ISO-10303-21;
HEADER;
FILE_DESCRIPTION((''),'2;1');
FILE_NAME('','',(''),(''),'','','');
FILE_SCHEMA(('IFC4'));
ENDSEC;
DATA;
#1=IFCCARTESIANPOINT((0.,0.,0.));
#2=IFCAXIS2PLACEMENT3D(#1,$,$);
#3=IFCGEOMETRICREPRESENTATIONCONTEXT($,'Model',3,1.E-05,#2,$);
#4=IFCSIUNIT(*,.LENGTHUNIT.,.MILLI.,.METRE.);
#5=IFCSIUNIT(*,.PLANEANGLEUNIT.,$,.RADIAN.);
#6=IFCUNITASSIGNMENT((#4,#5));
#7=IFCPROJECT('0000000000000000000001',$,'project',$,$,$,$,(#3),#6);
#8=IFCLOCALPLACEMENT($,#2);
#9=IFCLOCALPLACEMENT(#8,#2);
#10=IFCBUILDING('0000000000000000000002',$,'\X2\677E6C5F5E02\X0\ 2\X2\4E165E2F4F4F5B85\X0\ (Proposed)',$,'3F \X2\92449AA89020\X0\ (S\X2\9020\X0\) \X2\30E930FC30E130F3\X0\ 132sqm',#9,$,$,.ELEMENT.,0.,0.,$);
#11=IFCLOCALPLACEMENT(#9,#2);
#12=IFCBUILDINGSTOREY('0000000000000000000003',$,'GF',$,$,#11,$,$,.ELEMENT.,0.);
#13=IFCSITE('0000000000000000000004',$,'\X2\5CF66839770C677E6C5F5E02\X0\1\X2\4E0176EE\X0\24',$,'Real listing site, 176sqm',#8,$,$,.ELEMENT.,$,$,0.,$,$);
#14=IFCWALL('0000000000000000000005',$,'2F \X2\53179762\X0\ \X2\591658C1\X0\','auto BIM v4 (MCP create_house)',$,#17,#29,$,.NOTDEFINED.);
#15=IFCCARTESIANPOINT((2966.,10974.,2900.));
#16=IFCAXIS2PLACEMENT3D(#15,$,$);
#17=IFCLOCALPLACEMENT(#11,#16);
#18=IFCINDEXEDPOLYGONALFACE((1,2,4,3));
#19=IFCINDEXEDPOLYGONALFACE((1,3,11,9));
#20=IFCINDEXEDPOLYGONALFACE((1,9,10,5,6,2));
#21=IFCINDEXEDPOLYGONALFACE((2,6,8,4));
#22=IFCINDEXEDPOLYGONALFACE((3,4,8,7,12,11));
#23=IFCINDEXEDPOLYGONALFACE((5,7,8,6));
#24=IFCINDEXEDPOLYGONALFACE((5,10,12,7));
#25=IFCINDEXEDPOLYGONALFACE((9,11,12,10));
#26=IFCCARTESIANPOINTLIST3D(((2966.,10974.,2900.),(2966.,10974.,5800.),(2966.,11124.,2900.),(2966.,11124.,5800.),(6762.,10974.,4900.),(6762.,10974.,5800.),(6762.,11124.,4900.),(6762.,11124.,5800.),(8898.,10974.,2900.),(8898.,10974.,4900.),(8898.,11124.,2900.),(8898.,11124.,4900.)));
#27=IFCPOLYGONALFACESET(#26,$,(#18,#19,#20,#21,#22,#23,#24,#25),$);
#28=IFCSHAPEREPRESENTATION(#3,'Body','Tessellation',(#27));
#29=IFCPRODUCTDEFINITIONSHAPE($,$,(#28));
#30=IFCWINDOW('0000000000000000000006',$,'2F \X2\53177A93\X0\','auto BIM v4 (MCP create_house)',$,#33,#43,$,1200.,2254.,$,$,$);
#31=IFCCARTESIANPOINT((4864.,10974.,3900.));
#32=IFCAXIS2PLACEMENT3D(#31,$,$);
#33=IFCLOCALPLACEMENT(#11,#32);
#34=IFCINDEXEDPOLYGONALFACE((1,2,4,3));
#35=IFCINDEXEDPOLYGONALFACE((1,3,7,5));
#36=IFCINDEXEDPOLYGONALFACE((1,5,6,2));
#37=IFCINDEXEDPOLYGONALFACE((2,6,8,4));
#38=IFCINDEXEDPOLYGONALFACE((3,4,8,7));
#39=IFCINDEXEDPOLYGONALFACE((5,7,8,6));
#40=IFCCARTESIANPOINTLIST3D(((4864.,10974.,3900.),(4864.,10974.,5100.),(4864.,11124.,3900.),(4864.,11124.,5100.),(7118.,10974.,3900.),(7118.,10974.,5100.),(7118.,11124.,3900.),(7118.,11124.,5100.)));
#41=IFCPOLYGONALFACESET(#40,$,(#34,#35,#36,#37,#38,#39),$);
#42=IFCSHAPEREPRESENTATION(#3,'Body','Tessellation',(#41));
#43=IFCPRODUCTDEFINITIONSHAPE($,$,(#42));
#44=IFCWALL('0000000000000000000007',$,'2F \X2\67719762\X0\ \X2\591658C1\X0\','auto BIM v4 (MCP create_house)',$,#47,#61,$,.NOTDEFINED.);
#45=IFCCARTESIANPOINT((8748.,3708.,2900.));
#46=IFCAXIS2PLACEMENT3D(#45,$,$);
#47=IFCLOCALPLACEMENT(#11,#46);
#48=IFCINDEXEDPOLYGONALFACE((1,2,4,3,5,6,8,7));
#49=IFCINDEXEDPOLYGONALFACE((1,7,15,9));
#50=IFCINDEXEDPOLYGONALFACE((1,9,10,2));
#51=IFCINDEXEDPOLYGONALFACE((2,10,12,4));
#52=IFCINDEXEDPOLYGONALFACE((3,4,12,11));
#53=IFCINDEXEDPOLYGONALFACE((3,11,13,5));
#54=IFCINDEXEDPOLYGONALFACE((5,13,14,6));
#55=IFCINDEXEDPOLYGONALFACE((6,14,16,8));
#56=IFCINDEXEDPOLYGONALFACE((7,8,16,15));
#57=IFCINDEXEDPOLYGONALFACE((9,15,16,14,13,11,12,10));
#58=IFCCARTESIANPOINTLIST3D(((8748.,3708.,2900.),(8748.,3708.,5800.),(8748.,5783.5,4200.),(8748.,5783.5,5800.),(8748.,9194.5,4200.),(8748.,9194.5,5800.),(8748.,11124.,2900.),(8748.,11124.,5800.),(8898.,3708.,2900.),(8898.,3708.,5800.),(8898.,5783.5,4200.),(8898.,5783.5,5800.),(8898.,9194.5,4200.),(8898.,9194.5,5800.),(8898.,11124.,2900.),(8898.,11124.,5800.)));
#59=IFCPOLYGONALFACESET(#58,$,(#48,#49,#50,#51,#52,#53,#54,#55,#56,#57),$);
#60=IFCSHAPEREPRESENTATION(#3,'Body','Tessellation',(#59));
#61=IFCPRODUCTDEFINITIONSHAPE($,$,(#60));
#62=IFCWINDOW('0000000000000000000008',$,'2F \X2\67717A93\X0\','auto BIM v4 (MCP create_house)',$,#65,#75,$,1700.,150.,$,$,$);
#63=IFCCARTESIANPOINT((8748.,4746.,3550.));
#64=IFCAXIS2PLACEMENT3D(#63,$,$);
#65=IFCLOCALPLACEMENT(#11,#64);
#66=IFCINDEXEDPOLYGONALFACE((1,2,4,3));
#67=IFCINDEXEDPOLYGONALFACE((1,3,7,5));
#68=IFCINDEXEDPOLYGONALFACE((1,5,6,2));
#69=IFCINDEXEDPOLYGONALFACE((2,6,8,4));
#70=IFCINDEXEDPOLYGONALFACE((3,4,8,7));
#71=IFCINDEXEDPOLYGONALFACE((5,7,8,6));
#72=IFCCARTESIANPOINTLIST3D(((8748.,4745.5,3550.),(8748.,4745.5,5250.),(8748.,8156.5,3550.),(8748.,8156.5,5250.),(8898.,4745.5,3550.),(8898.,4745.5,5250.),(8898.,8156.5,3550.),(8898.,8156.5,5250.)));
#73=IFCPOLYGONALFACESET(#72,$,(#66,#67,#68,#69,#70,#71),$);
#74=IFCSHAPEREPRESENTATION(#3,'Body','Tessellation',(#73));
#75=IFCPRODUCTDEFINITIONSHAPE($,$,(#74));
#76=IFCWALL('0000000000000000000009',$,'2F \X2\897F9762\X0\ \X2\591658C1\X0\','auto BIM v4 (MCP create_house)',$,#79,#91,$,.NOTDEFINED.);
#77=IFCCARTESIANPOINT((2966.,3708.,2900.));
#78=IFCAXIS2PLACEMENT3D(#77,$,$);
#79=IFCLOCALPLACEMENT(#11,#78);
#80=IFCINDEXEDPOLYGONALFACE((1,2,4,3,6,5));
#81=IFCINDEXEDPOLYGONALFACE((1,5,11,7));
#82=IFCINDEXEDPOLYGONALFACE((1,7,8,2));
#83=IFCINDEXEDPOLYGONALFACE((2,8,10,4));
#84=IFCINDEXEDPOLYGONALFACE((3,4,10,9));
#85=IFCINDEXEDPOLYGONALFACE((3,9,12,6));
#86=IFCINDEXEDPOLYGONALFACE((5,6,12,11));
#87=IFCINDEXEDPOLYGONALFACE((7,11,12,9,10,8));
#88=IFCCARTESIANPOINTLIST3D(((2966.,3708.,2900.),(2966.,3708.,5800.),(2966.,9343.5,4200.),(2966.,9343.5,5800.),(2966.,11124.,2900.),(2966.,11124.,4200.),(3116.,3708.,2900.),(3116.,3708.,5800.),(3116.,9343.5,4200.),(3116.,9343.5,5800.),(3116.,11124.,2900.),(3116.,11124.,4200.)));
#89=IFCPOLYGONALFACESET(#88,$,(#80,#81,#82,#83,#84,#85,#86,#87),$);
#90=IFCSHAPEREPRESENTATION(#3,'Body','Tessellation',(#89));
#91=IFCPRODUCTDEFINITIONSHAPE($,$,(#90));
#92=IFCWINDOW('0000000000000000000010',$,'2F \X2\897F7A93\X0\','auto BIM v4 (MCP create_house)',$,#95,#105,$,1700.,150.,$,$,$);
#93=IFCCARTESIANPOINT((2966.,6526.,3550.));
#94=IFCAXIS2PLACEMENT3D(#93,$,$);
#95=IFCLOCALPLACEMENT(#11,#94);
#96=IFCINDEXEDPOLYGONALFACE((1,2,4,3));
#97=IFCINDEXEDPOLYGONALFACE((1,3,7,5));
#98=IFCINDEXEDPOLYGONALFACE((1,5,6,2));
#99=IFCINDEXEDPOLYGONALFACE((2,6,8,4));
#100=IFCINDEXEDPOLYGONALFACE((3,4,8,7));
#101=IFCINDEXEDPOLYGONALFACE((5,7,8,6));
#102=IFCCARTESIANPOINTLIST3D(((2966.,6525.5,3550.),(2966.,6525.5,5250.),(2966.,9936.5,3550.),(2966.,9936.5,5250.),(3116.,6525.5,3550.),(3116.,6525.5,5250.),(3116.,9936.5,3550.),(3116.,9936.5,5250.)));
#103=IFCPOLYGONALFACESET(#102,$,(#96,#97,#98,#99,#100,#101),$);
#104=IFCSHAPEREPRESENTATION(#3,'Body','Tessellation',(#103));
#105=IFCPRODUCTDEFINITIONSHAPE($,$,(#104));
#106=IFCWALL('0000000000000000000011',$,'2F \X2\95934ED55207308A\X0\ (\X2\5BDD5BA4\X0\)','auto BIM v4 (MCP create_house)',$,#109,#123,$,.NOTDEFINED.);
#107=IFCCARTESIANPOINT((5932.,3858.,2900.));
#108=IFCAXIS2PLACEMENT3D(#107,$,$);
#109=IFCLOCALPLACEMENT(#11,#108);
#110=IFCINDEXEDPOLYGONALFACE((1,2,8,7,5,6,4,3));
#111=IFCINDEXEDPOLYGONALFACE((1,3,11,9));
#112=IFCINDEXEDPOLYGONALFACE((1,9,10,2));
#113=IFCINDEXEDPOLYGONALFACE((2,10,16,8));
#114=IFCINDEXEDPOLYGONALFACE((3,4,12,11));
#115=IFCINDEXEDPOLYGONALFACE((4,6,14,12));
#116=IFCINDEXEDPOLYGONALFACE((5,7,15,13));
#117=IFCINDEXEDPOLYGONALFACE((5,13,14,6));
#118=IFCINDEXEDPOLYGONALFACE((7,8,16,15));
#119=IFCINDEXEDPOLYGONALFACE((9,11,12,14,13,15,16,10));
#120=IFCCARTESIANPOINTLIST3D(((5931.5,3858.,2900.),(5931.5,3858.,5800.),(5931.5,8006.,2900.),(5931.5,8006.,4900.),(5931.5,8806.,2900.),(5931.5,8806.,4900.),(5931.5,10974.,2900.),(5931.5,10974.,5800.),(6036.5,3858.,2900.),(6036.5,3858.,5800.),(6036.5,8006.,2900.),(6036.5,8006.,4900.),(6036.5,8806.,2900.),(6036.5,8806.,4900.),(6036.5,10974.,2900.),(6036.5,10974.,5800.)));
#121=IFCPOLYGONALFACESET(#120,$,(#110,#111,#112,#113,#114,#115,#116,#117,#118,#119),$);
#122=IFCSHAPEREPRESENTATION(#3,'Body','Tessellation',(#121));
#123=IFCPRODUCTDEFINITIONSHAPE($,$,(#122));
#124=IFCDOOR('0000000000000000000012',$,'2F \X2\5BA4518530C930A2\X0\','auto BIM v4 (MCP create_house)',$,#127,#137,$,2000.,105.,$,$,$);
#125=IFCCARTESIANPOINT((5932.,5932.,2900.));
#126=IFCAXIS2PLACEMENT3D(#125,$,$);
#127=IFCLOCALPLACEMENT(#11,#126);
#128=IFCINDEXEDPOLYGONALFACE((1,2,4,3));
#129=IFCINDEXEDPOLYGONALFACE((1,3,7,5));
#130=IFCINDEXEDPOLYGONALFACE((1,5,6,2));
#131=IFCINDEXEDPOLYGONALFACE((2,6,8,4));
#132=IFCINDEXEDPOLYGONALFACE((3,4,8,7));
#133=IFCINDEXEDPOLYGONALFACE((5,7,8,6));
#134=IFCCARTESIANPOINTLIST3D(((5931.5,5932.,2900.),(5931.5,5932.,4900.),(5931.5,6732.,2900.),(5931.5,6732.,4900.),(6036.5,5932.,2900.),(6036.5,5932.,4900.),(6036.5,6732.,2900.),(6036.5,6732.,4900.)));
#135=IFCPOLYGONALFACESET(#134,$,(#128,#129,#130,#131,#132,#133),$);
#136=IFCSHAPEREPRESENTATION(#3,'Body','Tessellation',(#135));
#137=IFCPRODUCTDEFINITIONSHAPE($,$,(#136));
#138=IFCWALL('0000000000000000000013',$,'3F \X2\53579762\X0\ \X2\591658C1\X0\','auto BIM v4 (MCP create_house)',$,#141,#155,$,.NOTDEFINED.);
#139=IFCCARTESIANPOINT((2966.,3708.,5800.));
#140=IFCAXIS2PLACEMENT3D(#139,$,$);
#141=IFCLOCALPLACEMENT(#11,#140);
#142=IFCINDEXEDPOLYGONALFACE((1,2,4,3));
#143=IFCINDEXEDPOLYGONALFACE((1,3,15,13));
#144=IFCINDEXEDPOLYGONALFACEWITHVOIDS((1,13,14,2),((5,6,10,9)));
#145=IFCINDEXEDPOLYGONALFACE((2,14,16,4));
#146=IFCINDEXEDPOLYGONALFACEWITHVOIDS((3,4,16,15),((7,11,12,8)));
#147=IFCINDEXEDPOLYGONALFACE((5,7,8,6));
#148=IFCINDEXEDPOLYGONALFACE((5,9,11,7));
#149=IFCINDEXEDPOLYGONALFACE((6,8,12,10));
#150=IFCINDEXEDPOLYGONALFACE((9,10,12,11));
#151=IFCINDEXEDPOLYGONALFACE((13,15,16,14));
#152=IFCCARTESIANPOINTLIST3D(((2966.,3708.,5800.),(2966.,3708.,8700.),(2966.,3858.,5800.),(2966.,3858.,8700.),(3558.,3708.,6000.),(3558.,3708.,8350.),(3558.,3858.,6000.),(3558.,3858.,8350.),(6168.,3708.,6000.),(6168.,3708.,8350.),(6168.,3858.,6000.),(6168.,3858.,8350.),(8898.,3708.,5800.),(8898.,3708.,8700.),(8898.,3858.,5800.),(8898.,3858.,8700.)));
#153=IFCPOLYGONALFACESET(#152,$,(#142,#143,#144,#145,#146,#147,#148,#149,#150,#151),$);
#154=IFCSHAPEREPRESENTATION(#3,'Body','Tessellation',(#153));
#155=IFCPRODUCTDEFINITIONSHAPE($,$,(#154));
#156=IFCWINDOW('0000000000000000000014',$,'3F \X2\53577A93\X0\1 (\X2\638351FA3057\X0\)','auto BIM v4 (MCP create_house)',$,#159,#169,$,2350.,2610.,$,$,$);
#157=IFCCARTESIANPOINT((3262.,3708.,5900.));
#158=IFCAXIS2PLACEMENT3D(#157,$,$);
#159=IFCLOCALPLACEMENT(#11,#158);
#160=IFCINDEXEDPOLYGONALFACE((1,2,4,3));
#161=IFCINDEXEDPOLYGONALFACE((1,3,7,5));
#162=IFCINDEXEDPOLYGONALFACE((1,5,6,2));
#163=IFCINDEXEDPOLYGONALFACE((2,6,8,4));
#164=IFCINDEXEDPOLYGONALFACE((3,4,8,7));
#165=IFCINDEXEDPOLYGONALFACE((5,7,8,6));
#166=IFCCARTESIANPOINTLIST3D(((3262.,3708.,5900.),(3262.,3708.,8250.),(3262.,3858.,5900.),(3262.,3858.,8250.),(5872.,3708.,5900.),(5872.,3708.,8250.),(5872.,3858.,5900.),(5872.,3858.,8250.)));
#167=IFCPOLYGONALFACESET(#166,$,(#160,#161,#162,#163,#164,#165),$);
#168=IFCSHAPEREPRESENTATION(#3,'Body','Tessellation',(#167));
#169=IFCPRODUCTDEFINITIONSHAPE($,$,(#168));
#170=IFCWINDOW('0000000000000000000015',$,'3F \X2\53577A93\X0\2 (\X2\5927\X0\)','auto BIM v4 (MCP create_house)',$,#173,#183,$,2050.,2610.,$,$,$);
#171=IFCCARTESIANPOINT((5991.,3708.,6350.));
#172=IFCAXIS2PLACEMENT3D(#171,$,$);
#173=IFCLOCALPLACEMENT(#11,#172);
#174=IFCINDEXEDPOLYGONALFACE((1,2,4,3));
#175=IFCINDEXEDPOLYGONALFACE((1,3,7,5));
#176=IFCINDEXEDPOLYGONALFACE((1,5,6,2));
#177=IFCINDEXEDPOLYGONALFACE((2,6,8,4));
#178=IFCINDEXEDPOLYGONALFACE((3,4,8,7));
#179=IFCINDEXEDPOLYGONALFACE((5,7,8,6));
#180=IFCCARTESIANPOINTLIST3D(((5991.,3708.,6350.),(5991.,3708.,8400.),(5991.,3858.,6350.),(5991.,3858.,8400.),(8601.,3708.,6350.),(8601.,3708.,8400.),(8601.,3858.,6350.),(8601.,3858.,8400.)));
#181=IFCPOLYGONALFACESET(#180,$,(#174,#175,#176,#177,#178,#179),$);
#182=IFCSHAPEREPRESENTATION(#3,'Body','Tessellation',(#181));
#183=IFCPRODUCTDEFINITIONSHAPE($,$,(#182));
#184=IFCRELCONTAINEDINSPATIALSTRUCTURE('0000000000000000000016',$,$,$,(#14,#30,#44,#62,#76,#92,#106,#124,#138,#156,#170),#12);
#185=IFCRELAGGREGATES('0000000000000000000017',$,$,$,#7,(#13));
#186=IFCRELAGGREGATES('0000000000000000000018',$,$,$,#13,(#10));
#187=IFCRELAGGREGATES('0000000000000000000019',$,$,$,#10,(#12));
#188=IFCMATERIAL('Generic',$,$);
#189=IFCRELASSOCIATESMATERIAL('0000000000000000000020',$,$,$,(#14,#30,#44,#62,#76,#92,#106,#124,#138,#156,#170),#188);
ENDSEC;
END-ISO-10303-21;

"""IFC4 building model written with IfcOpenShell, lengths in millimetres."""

from ifc_helpers import new_model, si_unit, frame, frame_2d, origin, place, context, project, spatial, rectangle, extrude, material, element, fill, save


model = new_model("IFC4")

# Units and contexts
model_context = context("Model", 3, precision=1e-05, world=origin())
ifc_project = project(units=[si_unit("LENGTHUNIT", "METRE", prefix="MILLI"), si_unit("PLANEANGLEUNIT", "RADIAN")], contexts=[model_context])

# Site, building, storey
site_placement = place(None, origin())
site = spatial("IfcSite", under=ifc_project, at=site_placement, Name="島根県松江市1丁目24", ObjectType="Real listing site, 176sqm", CompositionType="ELEMENT", RefElevation=0.0)
building_placement = place(site_placement, origin())
building = spatial("IfcBuilding", under=site, at=building_placement, Name="松江市 2世帯住宅 (Proposed)", ObjectType="3F 鉄骨造 (S造) ラーメン 132sqm", CompositionType="ELEMENT", ElevationOfRefHeight=0.0, ElevationOfTerrain=0.0)
storey_placement = place(building_placement, origin())
storey = spatial("IfcBuildingStorey", under=building, at=storey_placement, Name="GF", CompositionType="ELEMENT", Elevation=0.0)

# Shared definitions
ifc_material = material(Name="Generic")

# Walls, openings, windows
wall_1_placement = place(storey_placement, frame((2966.0, 10974.0, 2900.0)))
wall_1 = element("IfcWall", 1, at=wall_1_placement, inside=storey, material=ifc_material, Name="2F 北面 外壁", Description="auto BIM v4 (MCP create_house)", PredefinedType="NOTDEFINED", context=model_context, shape_type="SweptSolid", body=[
    extrude(rectangle(XDim=5932.0, YDim=150.0, at=frame_2d((2966.0, 75.0))), frame((2966.0, 10974.0, 2900.0)), (0.0, 0.0, 1.0), 2900.0),
])
opening_1_placement = place(storey_placement, frame((4864.0, 10974.0, 3900.0)))
opening_1 = element("IfcOpeningElement", 2, at=opening_1_placement, cuts=wall_1, PredefinedType="NOTDEFINED", context=model_context, shape_type="SweptSolid", body=[
    extrude(rectangle(XDim=2254.0, YDim=150.0, at=frame_2d((1127.0, 75.0))), frame((4864.0, 10974.0, 3900.0)), (0.0, 0.0, 1.0), 1200.0),
])
window_1_placement = place(storey_placement, frame((4864.0, 10974.0, 3900.0)))
window_1 = element("IfcWindow", 3, at=window_1_placement, inside=storey, material=ifc_material, Name="2F 北窓", Description="auto BIM v4 (MCP create_house)", OverallHeight=1200.0, OverallWidth=2254.0, context=model_context, shape_type="SweptSolid", body=[
    extrude(rectangle(XDim=2254.0, YDim=150.0, at=frame_2d((1127.0, 75.0))), frame((4864.0, 10974.0, 3900.0)), (0.0, 0.0, 1.0), 1200.0),
])
fill(opening_1, window_1)
wall_2_placement = place(storey_placement, frame((8748.0, 3708.0, 2900.0)))
wall_2 = element("IfcWall", 4, at=wall_2_placement, inside=storey, material=ifc_material, Name="2F 東面 外壁", Description="auto BIM v4 (MCP create_house)", PredefinedType="NOTDEFINED", context=model_context, shape_type="SweptSolid", body=[
    extrude(rectangle(XDim=150.0, YDim=7416.0, at=frame_2d((75.0, 3708.0))), frame((8748.0, 3708.0, 2900.0)), (0.0, 0.0, 1.0), 2900.0),
])
opening_2_placement = place(storey_placement, frame((8748.0, 4746.0, 3550.0)))
opening_2 = element("IfcOpeningElement", 5, at=opening_2_placement, cuts=wall_2, PredefinedType="NOTDEFINED", context=model_context, shape_type="SweptSolid", body=[
    extrude(rectangle(XDim=150.0, YDim=3411.0, at=frame_2d((75.0, 1705.0))), frame((8748.0, 4746.0, 3550.0)), (0.0, 0.0, 1.0), 1700.0),
])
window_2_placement = place(storey_placement, frame((8748.0, 4746.0, 3550.0)))
window_2 = element("IfcWindow", 6, at=window_2_placement, inside=storey, material=ifc_material, Name="2F 東窓", Description="auto BIM v4 (MCP create_house)", OverallHeight=1700.0, OverallWidth=150.0, context=model_context, shape_type="SweptSolid", body=[
    extrude(rectangle(XDim=150.0, YDim=3411.0, at=frame_2d((75.0, 1705.0))), frame((8748.0, 4746.0, 3550.0)), (0.0, 0.0, 1.0), 1700.0),
])
fill(opening_2, window_2)
wall_3_placement = place(storey_placement, frame((2966.0, 3708.0, 2900.0)))
wall_3 = element("IfcWall", 7, at=wall_3_placement, inside=storey, material=ifc_material, Name="2F 西面 外壁", Description="auto BIM v4 (MCP create_house)", PredefinedType="NOTDEFINED", context=model_context, shape_type="SweptSolid", body=[
    extrude(rectangle(XDim=150.0, YDim=7416.0, at=frame_2d((75.0, 3708.0))), frame((2966.0, 3708.0, 2900.0)), (0.0, 0.0, 1.0), 2900.0),
])
opening_3_placement = place(storey_placement, frame((2966.0, 6526.0, 3550.0)))
opening_3 = element("IfcOpeningElement", 8, at=opening_3_placement, cuts=wall_3, PredefinedType="NOTDEFINED", context=model_context, shape_type="SweptSolid", body=[
    extrude(rectangle(XDim=150.0, YDim=3411.0, at=frame_2d((75.0, 1705.0))), frame((2966.0, 6526.0, 3550.0)), (0.0, 0.0, 1.0), 1700.0),
])
window_3_placement = place(storey_placement, frame((2966.0, 6526.0, 3550.0)))
window_3 = element("IfcWindow", 9, at=window_3_placement, inside=storey, material=ifc_material, Name="2F 西窓", Description="auto BIM v4 (MCP create_house)", OverallHeight=1700.0, OverallWidth=150.0, context=model_context, shape_type="SweptSolid", body=[
    extrude(rectangle(XDim=150.0, YDim=3411.0, at=frame_2d((75.0, 1705.0))), frame((2966.0, 6526.0, 3550.0)), (0.0, 0.0, 1.0), 1700.0),
])
fill(opening_3, window_3)

# Wall, opening, door
wall_4_placement = place(storey_placement, frame((5932.0, 3858.0, 2900.0)))
wall_4 = element("IfcWall", 10, at=wall_4_placement, inside=storey, material=ifc_material, Name="2F 間仕切り (寝室)", Description="auto BIM v4 (MCP create_house)", PredefinedType="NOTDEFINED", context=model_context, shape_type="SweptSolid", body=[
    extrude(rectangle(XDim=105.0, YDim=7116.0, at=frame_2d((52.0, 3558.0))), frame((5932.0, 3858.0, 2900.0)), (0.0, 0.0, 1.0), 2900.0),
])
opening_4_placement = place(storey_placement, frame((5932.0, 5932.0, 2900.0)))
opening_4 = element("IfcOpeningElement", 11, at=opening_4_placement, cuts=wall_4, PredefinedType="NOTDEFINED", context=model_context, shape_type="SweptSolid", body=[
    extrude(rectangle(XDim=105.0, YDim=800.0, at=frame_2d((52.0, 400.0))), frame((5932.0, 5932.0, 2900.0)), (0.0, 0.0, 1.0), 2000.0),
])
door_1_placement = place(storey_placement, frame((5932.0, 5932.0, 2900.0)))
door_1 = element("IfcDoor", 12, at=door_1_placement, inside=storey, material=ifc_material, Name="2F 室内ドア", Description="auto BIM v4 (MCP create_house)", OverallHeight=2000.0, OverallWidth=105.0, context=model_context, shape_type="SweptSolid", body=[
    extrude(rectangle(XDim=105.0, YDim=800.0, at=frame_2d((52.0, 400.0))), frame((5932.0, 5932.0, 2900.0)), (0.0, 0.0, 1.0), 2000.0),
])
fill(opening_4, door_1)

# Wall, openings, windows
wall_5_placement = place(storey_placement, frame((2966.0, 3708.0, 5800.0)))
wall_5 = element("IfcWall", 13, at=wall_5_placement, inside=storey, material=ifc_material, Name="3F 南面 外壁", Description="auto BIM v4 (MCP create_house)", PredefinedType="NOTDEFINED", context=model_context, shape_type="SweptSolid", body=[
    extrude(rectangle(XDim=5932.0, YDim=150.0, at=frame_2d((2966.0, 75.0))), frame((2966.0, 3708.0, 5800.0)), (0.0, 0.0, 1.0), 2900.0),
])
opening_5_placement = place(storey_placement, frame((3262.0, 3708.0, 5900.0)))
opening_5 = element("IfcOpeningElement", 14, at=opening_5_placement, cuts=wall_5, PredefinedType="NOTDEFINED", context=model_context, shape_type="SweptSolid", body=[
    extrude(rectangle(XDim=2610.0, YDim=150.0, at=frame_2d((1305.0, 75.0))), frame((3262.0, 3708.0, 5900.0)), (0.0, 0.0, 1.0), 2350.0),
])
opening_6_placement = place(storey_placement, frame((5991.0, 3708.0, 6350.0)))
opening_6 = element("IfcOpeningElement", 15, at=opening_6_placement, cuts=wall_5, PredefinedType="NOTDEFINED", context=model_context, shape_type="SweptSolid", body=[
    extrude(rectangle(XDim=2610.0, YDim=150.0, at=frame_2d((1305.0, 75.0))), frame((5991.0, 3708.0, 6350.0)), (0.0, 0.0, 1.0), 2050.0),
])
window_4_placement = place(storey_placement, frame((3262.0, 3708.0, 5900.0)))
window_4 = element("IfcWindow", 16, at=window_4_placement, inside=storey, material=ifc_material, Name="3F 南窓1 (掃出し)", Description="auto BIM v4 (MCP create_house)", OverallHeight=2350.0, OverallWidth=2610.0, context=model_context, shape_type="SweptSolid", body=[
    extrude(rectangle(XDim=2610.0, YDim=150.0, at=frame_2d((1305.0, 75.0))), frame((3262.0, 3708.0, 5900.0)), (0.0, 0.0, 1.0), 2350.0),
])
fill(opening_5, window_4)
window_5_placement = place(storey_placement, frame((5991.0, 3708.0, 6350.0)))
window_5 = element("IfcWindow", 17, at=window_5_placement, inside=storey, material=ifc_material, Name="3F 南窓2 (大)", Description="auto BIM v4 (MCP create_house)", OverallHeight=2050.0, OverallWidth=2610.0, context=model_context, shape_type="SweptSolid", body=[
    extrude(rectangle(XDim=2610.0, YDim=150.0, at=frame_2d((1305.0, 75.0))), frame((5991.0, 3708.0, 6350.0)), (0.0, 0.0, 1.0), 2050.0),
])
fill(opening_6, window_5)

save(model, "model.ifc")
